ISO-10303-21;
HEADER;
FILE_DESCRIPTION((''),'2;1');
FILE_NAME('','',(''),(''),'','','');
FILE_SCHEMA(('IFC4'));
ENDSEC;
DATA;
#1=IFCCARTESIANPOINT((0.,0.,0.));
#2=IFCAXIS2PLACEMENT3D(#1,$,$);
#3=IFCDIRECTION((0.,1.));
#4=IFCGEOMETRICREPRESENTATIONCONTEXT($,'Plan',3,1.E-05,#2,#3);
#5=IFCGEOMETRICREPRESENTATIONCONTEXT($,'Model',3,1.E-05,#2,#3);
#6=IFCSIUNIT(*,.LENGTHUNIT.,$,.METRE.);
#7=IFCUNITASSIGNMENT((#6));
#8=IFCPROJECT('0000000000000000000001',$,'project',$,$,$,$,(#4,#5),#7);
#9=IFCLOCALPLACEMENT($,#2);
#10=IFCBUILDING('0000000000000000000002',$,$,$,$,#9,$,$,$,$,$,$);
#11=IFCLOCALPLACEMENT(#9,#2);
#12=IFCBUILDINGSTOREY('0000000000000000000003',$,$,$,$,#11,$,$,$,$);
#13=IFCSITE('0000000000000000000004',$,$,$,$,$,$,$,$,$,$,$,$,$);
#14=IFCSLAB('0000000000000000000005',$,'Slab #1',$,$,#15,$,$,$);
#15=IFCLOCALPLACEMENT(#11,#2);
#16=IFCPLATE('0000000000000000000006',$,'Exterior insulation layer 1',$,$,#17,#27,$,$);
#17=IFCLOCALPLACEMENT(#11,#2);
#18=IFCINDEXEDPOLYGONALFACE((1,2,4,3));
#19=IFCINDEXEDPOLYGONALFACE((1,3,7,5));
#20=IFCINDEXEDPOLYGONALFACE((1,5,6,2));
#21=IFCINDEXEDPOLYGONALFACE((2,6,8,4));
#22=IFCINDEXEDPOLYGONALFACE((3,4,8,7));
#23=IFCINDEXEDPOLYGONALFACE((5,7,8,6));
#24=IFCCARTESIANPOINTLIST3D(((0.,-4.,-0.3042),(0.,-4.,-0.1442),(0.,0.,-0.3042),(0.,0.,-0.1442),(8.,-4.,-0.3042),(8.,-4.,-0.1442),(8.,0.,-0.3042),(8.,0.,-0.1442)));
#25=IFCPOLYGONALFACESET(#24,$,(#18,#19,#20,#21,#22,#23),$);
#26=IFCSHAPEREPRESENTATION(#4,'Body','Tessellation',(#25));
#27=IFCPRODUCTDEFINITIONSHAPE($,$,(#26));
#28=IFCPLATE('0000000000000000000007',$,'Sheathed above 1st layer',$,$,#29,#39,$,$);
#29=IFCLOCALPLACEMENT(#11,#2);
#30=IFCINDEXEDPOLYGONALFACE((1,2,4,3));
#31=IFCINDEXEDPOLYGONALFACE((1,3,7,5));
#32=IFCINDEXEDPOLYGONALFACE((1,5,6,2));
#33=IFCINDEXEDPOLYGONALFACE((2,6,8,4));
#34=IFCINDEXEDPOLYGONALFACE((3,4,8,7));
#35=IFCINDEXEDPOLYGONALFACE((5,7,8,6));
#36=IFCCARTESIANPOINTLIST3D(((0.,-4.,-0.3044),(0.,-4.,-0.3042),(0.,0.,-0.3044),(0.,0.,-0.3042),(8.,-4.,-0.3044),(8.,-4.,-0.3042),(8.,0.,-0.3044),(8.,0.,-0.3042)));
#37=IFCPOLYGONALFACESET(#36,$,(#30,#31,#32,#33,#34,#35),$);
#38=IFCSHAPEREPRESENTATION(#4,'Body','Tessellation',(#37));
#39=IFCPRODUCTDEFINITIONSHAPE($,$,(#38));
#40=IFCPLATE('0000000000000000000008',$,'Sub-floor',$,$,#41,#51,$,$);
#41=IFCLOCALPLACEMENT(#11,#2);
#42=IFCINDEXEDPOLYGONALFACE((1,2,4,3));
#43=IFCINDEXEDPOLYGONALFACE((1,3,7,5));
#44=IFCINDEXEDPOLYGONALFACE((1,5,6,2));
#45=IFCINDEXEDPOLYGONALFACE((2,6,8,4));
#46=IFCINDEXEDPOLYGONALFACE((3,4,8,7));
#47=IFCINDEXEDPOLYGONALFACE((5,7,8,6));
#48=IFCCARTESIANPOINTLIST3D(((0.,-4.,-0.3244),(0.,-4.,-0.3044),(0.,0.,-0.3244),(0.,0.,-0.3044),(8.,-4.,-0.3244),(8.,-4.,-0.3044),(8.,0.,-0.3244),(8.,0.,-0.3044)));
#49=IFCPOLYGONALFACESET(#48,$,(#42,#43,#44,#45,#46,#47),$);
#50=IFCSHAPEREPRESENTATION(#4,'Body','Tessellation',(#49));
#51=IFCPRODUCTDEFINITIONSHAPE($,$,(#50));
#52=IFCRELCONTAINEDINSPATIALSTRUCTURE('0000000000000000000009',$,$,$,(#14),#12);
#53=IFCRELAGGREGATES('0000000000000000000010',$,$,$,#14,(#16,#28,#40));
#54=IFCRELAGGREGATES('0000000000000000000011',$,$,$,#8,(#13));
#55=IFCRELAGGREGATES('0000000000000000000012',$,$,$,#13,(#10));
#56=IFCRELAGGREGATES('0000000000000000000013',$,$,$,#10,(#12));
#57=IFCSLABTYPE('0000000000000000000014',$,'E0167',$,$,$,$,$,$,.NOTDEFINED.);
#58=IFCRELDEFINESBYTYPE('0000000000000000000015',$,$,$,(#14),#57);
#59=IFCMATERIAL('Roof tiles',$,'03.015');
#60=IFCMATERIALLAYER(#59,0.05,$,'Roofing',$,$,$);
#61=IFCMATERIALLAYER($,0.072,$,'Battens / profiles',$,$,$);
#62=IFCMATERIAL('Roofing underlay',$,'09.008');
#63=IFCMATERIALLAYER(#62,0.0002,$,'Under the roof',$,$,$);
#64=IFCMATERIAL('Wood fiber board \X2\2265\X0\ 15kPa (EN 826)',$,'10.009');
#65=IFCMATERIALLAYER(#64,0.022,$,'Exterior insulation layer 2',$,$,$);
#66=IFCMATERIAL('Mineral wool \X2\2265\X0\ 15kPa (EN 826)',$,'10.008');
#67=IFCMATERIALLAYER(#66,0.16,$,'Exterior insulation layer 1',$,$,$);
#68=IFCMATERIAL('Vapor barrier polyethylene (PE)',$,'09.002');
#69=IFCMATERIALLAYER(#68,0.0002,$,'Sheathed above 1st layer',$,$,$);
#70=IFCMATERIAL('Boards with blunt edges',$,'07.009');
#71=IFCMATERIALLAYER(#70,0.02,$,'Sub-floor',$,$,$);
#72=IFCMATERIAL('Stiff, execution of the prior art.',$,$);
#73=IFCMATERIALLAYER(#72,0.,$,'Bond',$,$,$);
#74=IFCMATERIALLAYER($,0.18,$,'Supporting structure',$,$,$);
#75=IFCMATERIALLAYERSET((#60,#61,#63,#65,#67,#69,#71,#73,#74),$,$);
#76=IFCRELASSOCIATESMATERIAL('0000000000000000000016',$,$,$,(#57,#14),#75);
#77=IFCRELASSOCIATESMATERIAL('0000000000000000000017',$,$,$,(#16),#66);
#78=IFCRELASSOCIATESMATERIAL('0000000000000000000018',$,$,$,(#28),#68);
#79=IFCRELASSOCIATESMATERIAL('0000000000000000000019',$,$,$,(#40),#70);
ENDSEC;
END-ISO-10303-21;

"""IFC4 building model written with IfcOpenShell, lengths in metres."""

from ifc_helpers import new_model, si_unit, direction, frame, frame_2d, origin, place, context, project, spatial, rectangle, extrude, material, layer, layer_set, type_object, element, aggregate, save


model = new_model("IFC4")

# Units and contexts
plan_context = context("Plan", 3, precision=1e-05, world=origin(), true_north=direction((0.0, 1.0)))
model_context = context("Model", 3, precision=1e-05, world=origin(), true_north=direction((0.0, 1.0)))
ifc_project = project(units=[si_unit("LENGTHUNIT", "METRE")], contexts=[plan_context, model_context])

# Site, building, storey
site = spatial("IfcSite", under=ifc_project)
building_placement = place(None, origin())
building = spatial("IfcBuilding", under=site, at=building_placement)
storey_placement = place(building_placement, origin())
storey = spatial("IfcBuildingStorey", under=building, at=storey_placement)

# Slab, plates
ifc_material_1 = material(Name="Roof tiles", Category="03.015")
ifc_layer_1 = layer(ifc_material_1, 0.05, Name="Roofing")
ifc_layer_2 = layer(None, 0.072, Name="Battens / profiles")
ifc_material_2 = material(Name="Roofing underlay", Category="09.008")
ifc_layer_3 = layer(ifc_material_2, 0.0002, Name="Under the roof")
ifc_material_3 = material(Name="Wood fiber board ≥ 15kPa (EN 826)", Category="10.009")
ifc_layer_4 = layer(ifc_material_3, 0.022, Name="Exterior insulation layer 2")
ifc_material_4 = material(Name="Mineral wool ≥ 15kPa (EN 826)", Category="10.008")
ifc_layer_5 = layer(ifc_material_4, 0.16, Name="Exterior insulation layer 1")
ifc_material_5 = material(Name="Vapor barrier polyethylene (PE)", Category="09.002")
ifc_layer_6 = layer(ifc_material_5, 0.0002, Name="Sheathed above 1st layer")
ifc_material_6 = material(Name="Boards with blunt edges", Category="07.009")
ifc_layer_7 = layer(ifc_material_6, 0.02, Name="Sub-floor")
ifc_material_7 = material(Name="Stiff, execution of the prior art.")
ifc_layer_8 = layer(ifc_material_7, 0.0, Name="Bond")
ifc_layer_9 = layer(None, 0.18, Name="Supporting structure")
ifc_layer_set = layer_set([ifc_layer_1, ifc_layer_2, ifc_layer_3, ifc_layer_4, ifc_layer_5, ifc_layer_6, ifc_layer_7, ifc_layer_8, ifc_layer_9])
slab_type = type_object("IfcSlabType", Name="E0167", PredefinedType="NOTDEFINED", material=ifc_layer_set)
slab_placement = place(None, frame((0.0, 0.0, 0.0), z_axis=(0.0, 0.0, -1.0), x_axis=(1.0, 0.0, 0.0)))
slab = element("IfcSlab", 1, at=slab_placement, inside=storey, type_object=slab_type, material=ifc_layer_set, Name="Slab #1")
plate_1_placement = place(slab_placement, origin())
plate_1 = element("IfcPlate", 2, at=plate_1_placement, material=ifc_material_4, Name="Exterior insulation layer 1", context=plan_context, shape_type="SweptSolid", body=[
    extrude(rectangle(XDim=8.0, YDim=4.0, at=frame_2d((4.0, 2.0), x_axis=(1.0, 0.0))), frame((0.0, 0.0, 0.1442), z_axis=(0.0, 0.0, 1.0), x_axis=(1.0, 0.0, 0.0)), (0.0, 0.0, 1.0), 0.16),
])
plate_2_placement = place(slab_placement, origin())
plate_2 = element("IfcPlate", 3, at=plate_2_placement, material=ifc_material_5, Name="Sheathed above 1st layer", context=plan_context, shape_type="SweptSolid", body=[
    extrude(rectangle(XDim=8.0, YDim=4.0, at=frame_2d((4.0, 2.0), x_axis=(1.0, 0.0))), frame((0.0, 0.0, 0.3042), z_axis=(0.0, 0.0, 1.0), x_axis=(1.0, 0.0, 0.0)), (0.0, 0.0, 1.0), 0.0002),
])
plate_3_placement = place(slab_placement, origin())
plate_3 = element("IfcPlate", 4, at=plate_3_placement, material=ifc_material_6, Name="Sub-floor", context=plan_context, shape_type="SweptSolid", body=[
    extrude(rectangle(XDim=8.0, YDim=4.0, at=frame_2d((4.0, 2.0), x_axis=(1.0, 0.0))), frame((0.0, 0.0, 0.3044), z_axis=(0.0, 0.0, 1.0), x_axis=(1.0, 0.0, 0.0)), (0.0, 0.0, 1.0), 0.02),
])
aggregate(slab, [plate_1, plate_2, plate_3])

save(model, "model.ifc")
